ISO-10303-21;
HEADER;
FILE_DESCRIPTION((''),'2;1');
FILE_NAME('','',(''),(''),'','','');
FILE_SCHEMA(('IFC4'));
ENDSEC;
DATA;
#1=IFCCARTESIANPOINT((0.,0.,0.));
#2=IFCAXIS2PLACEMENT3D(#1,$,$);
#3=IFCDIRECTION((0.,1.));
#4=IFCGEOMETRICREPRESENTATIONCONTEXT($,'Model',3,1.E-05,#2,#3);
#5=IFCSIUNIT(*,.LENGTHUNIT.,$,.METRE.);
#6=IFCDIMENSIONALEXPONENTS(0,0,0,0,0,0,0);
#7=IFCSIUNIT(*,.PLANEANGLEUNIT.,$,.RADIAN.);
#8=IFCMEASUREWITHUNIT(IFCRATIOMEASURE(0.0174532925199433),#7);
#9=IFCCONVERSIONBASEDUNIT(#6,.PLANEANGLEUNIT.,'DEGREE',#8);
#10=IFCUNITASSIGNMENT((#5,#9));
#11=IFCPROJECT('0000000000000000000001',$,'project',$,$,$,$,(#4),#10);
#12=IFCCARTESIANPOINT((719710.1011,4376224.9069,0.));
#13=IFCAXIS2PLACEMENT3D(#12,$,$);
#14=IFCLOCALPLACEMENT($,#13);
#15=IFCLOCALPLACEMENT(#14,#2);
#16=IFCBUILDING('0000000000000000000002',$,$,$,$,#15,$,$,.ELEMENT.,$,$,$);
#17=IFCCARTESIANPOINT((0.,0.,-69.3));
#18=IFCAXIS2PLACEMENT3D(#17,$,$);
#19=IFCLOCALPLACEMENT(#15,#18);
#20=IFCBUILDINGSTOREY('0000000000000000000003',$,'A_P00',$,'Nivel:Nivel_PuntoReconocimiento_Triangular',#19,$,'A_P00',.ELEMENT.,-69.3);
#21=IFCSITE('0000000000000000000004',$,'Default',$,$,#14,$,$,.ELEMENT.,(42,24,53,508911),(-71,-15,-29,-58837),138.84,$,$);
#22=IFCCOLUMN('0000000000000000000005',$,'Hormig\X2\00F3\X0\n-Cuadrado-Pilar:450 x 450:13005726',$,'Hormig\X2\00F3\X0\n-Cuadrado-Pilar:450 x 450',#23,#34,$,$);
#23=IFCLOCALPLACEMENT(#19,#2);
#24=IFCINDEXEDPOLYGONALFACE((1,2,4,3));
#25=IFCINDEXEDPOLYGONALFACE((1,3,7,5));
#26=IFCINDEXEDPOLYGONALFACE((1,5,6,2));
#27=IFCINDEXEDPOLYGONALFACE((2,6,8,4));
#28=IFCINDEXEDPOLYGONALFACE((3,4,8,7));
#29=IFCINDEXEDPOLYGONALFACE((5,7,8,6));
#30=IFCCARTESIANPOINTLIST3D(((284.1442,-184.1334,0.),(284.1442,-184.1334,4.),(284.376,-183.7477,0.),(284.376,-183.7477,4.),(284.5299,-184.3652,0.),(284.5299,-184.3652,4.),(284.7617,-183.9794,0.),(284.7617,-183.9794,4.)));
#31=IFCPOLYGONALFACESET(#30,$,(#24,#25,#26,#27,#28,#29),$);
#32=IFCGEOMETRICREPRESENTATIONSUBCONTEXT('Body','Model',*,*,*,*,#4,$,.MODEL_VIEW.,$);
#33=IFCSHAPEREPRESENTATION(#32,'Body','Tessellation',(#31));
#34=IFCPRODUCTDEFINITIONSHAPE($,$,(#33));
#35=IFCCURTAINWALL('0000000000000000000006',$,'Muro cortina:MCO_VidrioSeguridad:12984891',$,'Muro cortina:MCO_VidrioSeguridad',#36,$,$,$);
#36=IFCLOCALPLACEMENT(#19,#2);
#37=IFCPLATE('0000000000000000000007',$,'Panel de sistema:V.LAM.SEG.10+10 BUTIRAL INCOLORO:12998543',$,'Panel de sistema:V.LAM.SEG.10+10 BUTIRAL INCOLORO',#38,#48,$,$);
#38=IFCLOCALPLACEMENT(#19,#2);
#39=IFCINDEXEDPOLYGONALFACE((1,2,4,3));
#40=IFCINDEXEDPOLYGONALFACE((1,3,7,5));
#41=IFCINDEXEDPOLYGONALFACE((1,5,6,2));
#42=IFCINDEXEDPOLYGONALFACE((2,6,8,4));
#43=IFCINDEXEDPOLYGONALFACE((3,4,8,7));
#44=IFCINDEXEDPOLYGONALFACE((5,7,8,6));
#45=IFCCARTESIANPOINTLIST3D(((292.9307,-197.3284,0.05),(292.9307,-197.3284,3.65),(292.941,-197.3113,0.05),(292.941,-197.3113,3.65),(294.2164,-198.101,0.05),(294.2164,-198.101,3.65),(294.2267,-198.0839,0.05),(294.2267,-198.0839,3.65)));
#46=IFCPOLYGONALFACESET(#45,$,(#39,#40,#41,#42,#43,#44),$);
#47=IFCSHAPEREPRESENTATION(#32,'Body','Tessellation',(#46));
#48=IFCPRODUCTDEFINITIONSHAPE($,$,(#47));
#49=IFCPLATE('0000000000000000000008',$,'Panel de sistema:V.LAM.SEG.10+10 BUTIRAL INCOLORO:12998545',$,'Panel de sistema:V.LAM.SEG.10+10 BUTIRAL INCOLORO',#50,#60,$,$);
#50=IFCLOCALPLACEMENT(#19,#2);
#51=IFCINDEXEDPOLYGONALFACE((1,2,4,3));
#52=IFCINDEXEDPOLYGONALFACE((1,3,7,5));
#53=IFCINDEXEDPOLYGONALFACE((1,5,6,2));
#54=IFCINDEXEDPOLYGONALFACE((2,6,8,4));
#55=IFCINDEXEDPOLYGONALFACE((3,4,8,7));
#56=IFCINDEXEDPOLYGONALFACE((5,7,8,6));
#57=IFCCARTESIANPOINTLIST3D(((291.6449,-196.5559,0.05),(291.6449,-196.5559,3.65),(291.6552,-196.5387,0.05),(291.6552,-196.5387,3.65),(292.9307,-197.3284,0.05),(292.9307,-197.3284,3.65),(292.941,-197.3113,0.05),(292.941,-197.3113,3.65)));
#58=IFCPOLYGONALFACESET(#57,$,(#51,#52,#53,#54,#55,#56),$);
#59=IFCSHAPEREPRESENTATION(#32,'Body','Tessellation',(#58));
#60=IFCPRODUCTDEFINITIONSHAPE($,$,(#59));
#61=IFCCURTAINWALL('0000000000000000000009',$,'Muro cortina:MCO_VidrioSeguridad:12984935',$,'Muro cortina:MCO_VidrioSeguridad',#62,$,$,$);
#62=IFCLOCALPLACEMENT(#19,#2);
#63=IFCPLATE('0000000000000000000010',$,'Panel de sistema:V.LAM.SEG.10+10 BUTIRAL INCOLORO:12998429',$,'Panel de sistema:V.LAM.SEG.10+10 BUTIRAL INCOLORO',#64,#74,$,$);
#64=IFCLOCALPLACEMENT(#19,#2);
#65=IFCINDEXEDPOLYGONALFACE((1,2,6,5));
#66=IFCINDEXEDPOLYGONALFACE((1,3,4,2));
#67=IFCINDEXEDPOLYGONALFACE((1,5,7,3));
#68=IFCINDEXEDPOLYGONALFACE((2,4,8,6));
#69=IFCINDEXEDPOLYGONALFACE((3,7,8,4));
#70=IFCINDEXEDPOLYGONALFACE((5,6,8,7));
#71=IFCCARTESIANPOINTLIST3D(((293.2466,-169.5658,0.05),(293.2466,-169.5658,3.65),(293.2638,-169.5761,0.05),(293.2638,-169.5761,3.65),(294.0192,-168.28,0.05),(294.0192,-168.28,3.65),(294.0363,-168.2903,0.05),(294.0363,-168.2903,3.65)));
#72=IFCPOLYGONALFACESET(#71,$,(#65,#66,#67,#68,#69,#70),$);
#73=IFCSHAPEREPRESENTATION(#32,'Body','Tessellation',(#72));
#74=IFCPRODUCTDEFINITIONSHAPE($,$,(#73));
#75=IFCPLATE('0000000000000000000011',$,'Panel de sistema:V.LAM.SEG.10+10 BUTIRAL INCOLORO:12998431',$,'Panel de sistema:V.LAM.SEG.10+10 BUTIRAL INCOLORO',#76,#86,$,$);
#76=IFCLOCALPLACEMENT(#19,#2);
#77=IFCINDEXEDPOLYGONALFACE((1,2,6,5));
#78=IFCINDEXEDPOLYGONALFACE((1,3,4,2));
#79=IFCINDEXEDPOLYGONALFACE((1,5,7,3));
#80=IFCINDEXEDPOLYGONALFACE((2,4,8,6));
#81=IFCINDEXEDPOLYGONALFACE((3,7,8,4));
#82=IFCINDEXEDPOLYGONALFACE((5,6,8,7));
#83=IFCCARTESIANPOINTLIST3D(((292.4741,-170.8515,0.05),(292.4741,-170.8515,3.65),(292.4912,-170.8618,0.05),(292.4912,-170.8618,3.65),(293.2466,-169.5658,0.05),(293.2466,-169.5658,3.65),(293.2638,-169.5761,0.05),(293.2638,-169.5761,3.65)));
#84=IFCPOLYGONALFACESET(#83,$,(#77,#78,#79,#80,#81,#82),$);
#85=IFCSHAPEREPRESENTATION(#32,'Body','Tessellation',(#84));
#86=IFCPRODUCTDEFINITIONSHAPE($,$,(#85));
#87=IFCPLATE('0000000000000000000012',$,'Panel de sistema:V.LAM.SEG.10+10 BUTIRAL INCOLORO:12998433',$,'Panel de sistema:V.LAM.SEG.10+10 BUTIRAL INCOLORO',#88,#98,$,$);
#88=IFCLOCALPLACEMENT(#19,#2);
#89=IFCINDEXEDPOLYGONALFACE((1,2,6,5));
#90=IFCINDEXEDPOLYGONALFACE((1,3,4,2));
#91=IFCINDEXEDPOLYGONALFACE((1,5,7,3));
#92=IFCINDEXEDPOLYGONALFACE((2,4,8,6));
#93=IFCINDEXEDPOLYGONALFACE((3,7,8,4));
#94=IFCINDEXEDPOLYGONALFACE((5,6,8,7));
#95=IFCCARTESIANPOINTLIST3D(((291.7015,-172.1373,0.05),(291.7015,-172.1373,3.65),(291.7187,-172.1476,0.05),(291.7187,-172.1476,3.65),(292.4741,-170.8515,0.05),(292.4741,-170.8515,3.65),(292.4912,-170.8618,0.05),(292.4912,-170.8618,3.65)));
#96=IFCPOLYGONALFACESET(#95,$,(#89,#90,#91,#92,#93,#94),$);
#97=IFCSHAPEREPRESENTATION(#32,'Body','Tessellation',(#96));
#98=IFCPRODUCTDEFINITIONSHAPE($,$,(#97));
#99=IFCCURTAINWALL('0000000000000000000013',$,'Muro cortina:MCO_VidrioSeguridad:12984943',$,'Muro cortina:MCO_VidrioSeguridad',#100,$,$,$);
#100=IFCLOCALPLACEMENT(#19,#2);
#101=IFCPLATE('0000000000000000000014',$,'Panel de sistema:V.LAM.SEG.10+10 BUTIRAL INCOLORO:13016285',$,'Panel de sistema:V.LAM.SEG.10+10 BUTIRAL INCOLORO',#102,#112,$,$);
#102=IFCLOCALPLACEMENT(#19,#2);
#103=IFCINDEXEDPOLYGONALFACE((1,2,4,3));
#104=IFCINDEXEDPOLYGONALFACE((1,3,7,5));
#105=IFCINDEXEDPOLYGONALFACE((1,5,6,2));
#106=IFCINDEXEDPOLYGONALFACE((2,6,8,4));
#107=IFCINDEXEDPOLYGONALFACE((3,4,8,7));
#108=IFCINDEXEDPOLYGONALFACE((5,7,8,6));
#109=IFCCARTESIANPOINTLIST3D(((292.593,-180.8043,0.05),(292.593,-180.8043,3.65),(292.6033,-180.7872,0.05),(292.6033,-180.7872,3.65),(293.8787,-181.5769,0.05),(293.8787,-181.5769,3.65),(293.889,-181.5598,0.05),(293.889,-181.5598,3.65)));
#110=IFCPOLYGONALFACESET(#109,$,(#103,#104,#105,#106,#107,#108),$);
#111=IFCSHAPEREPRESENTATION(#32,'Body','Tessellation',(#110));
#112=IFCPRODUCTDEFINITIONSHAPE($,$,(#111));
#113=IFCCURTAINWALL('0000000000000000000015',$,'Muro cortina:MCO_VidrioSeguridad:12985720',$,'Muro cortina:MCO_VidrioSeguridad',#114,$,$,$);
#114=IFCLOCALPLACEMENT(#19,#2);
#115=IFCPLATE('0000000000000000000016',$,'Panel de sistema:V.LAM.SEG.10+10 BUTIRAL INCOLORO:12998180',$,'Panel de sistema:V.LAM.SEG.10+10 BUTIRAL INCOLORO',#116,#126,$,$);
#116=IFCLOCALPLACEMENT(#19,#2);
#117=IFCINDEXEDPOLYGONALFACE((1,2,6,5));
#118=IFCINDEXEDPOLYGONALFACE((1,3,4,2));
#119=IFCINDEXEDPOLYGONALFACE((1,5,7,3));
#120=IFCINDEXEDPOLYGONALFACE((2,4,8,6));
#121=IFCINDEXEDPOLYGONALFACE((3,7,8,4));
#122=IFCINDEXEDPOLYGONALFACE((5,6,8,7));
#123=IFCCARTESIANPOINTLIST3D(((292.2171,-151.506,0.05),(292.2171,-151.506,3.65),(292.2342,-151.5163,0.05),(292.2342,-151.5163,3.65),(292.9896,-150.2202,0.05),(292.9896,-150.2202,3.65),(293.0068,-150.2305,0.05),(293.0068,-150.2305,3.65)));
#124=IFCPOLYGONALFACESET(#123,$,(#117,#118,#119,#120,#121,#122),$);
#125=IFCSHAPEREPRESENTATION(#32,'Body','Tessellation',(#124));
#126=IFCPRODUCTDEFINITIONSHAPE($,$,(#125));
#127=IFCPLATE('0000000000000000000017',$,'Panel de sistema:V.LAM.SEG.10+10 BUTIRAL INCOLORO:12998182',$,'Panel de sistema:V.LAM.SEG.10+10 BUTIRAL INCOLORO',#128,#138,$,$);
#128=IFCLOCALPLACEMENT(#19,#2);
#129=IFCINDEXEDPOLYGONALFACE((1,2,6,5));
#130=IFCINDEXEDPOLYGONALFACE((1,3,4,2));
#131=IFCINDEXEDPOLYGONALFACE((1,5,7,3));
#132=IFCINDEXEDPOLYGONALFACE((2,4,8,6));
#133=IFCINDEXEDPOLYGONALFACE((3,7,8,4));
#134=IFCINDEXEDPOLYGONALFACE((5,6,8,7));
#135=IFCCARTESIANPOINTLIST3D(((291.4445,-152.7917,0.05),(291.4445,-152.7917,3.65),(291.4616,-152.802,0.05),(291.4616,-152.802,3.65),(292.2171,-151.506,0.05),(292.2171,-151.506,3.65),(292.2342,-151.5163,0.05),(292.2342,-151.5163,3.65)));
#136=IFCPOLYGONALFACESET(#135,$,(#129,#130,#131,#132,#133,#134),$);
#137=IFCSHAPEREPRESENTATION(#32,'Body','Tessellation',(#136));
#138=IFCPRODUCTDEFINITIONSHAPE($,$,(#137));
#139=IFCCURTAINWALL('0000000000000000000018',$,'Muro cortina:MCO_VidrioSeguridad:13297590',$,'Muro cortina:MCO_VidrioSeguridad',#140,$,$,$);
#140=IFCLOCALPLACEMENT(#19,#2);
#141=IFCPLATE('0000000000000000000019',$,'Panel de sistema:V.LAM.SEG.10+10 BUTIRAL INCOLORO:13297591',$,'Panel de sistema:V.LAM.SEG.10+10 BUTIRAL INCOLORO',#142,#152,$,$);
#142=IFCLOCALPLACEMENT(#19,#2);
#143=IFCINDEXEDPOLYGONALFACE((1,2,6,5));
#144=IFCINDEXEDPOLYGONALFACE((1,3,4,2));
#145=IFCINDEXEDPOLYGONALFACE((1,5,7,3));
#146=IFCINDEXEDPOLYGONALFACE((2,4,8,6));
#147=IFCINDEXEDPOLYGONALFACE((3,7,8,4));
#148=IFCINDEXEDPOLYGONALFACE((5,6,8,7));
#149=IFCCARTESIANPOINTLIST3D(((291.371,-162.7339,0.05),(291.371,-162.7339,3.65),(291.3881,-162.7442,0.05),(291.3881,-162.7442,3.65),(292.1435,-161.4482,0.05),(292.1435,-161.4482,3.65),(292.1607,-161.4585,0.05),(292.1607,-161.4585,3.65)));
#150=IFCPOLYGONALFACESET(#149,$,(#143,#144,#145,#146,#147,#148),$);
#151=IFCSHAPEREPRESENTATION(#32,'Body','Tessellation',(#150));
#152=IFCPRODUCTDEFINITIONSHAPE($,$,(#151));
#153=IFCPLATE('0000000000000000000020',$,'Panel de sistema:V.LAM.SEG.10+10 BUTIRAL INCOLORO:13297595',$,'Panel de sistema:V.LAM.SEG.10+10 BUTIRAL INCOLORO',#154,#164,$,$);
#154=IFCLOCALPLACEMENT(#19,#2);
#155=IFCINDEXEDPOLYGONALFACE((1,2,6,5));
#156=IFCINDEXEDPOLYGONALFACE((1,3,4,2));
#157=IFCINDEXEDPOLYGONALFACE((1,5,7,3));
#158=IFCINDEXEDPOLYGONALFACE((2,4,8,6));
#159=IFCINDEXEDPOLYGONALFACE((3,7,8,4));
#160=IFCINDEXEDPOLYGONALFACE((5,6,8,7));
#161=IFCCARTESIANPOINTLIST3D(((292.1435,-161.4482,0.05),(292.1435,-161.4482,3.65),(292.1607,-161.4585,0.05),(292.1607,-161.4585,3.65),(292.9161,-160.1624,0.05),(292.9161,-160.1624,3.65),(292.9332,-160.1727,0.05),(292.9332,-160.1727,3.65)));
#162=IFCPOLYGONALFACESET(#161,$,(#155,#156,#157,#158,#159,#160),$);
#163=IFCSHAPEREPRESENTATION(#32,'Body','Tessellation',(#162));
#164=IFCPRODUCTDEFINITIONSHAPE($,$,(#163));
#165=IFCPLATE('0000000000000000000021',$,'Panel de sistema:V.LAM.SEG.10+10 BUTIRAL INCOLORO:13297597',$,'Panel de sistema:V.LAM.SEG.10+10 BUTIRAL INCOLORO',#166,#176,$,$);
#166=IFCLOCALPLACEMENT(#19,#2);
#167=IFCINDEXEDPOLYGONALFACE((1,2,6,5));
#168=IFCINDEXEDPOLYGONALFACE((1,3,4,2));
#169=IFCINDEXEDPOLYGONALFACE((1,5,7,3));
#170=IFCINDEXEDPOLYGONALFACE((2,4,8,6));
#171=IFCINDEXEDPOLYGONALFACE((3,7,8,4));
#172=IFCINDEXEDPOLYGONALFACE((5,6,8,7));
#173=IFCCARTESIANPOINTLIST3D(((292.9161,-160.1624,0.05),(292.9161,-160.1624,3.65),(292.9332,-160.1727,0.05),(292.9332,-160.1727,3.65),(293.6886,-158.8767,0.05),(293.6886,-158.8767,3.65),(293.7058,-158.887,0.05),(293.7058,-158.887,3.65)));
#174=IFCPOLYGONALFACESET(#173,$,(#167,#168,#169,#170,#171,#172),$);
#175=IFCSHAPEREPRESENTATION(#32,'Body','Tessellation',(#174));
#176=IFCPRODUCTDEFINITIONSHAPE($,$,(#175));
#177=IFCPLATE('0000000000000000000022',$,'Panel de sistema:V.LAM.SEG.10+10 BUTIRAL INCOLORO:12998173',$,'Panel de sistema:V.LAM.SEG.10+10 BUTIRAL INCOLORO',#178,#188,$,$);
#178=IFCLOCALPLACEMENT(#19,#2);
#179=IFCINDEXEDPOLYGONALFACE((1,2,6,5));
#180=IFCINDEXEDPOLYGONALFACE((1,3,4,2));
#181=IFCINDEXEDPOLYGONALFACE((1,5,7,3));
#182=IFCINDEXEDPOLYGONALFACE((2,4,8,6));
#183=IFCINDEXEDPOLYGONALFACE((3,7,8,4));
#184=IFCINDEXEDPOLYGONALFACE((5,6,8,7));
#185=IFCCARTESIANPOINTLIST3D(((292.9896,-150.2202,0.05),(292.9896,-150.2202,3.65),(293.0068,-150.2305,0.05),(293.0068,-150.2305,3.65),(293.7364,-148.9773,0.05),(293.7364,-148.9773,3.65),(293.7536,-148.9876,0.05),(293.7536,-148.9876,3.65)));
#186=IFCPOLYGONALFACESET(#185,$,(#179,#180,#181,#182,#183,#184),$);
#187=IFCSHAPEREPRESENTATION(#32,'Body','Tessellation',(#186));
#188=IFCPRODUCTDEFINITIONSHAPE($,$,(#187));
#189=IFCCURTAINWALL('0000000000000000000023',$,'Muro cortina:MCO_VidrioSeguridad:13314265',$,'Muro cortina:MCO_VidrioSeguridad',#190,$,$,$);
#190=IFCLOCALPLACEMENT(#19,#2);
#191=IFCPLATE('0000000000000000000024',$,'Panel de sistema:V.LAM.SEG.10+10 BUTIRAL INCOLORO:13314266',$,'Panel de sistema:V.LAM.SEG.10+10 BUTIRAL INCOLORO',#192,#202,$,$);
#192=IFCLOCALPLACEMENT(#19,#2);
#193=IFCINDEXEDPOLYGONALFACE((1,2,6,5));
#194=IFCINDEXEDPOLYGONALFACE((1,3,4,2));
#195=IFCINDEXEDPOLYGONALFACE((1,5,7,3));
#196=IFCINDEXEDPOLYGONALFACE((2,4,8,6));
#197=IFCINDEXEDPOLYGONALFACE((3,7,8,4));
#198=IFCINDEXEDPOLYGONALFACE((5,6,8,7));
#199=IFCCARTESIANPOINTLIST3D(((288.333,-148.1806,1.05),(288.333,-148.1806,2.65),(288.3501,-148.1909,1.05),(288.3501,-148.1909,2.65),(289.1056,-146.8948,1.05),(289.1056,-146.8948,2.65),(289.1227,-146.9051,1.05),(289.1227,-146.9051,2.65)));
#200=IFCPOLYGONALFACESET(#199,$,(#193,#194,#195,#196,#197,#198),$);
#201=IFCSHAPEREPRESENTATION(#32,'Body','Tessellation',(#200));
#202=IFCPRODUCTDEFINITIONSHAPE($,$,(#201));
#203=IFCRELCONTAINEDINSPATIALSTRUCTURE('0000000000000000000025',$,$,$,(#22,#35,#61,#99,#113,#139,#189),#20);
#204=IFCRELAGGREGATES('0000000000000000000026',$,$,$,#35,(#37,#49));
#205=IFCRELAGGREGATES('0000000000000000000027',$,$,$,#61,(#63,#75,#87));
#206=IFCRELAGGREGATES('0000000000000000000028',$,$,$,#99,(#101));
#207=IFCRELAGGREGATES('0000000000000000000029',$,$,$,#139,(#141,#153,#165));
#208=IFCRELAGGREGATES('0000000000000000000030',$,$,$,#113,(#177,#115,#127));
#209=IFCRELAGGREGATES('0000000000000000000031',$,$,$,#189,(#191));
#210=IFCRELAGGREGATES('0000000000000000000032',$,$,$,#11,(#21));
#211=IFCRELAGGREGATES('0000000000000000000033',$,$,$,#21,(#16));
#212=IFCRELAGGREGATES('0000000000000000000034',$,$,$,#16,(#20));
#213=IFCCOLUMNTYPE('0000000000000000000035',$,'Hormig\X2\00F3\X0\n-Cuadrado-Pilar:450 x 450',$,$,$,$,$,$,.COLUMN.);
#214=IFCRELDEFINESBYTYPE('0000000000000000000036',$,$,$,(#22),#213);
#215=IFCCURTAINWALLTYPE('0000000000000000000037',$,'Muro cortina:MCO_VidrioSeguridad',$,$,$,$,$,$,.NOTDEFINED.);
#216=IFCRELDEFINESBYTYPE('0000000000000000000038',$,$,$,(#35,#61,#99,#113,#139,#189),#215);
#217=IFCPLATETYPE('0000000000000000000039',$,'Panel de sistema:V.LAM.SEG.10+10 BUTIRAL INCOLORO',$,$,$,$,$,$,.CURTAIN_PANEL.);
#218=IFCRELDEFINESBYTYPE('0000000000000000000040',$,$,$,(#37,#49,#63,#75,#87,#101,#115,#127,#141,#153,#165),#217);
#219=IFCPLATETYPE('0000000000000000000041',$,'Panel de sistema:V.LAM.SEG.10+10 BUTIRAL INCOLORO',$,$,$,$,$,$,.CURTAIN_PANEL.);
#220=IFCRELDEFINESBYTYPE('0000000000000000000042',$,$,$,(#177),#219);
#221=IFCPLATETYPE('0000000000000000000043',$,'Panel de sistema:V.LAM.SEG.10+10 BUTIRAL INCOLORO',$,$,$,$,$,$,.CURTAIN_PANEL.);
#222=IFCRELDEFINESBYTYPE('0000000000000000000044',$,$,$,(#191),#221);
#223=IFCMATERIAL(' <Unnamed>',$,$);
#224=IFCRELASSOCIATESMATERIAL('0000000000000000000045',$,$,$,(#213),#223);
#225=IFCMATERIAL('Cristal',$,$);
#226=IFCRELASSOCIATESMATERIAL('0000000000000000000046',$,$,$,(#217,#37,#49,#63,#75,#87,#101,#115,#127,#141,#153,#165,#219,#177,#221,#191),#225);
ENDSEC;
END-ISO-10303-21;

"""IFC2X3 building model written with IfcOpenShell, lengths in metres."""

from ifc_helpers import new_model, entity, si_unit, converted_unit, direction, frame, frame_2d, origin, origin_2d_with_axis, place, context, subcontext, project, spatial, rectangle, extrude, source, transform, mapped, material, type_object, type_shapes, element, aggregate, save


model = new_model("IFC2X3")

# Units and contexts
model_context = context("Model", 3, precision=1e-05, world=origin(), true_north=direction((0.0, 1.0)))
body_context = subcontext(model_context, "Body", "Model", "MODEL_VIEW")
ifc_project = project(units=[si_unit("LENGTHUNIT", "METRE"), converted_unit("PLANEANGLEUNIT", "DEGREE", entity("IfcRatioMeasure", 0.0174532925199433), si_unit("PLANEANGLEUNIT", "RADIAN"), dimensions=[0, 0, 0, 0, 0, 0, 0])], contexts=[model_context])

# Site, building, storey
site_placement = place(None, frame((719710.1011, 4376224.9069, 0.0)))
site = spatial("IfcSite", under=ifc_project, at=site_placement, Name="Default", CompositionType="ELEMENT", RefLatitude=(42, 24, 53, 508911), RefLongitude=(-71, -15, -29, -58837), RefElevation=138.84)
building_placement = place(site_placement, origin())
building = spatial("IfcBuilding", under=site, at=building_placement, CompositionType="ELEMENT")
storey_placement = place(building_placement, frame((0.0, 0.0, -69.3)))
storey = spatial("IfcBuildingStorey", under=building, at=storey_placement, Name="A_P00", ObjectType="Nivel:Nivel_PuntoReconocimiento_Triangular", LongName="A_P00", CompositionType="ELEMENT", Elevation=-69.3)

# Column
ifc_material_1 = material(Name=" <Unnamed>")
column_type = type_object("IfcColumnType", Name="Hormigón-Cuadrado-Pilar:450 x 450", PredefinedType="COLUMN", material=ifc_material_1)
shared_shape_1 = source(origin(), body_context, "Body", "SweptSolid", [
    extrude(rectangle(XDim=0.45, YDim=0.45, at=origin_2d_with_axis()), frame((0.0, 0.0, -69.3), z_axis=(0.0, 0.0, 1.0), x_axis=(0.0, -1.0, 0.0)), (0.0, 0.0, 1.0), 4.0),
])
type_shapes(column_type, [shared_shape_1])
column_placement = place(storey_placement, frame((284.4529, -184.0564, 69.3), z_axis=(0.0, 0.0, 1.0), x_axis=(0.857167, -0.515038, 0.0)))
element("IfcColumn", 1, at=column_placement, inside=storey, type_object=column_type, Name="Hormigón-Cuadrado-Pilar:450 x 450:13005726", ObjectType="Hormigón-Cuadrado-Pilar:450 x 450", context=body_context, shape_type="MappedRepresentation", body=[
    mapped(shared_shape_1, transform((0.0, 0.0, 0.0), scale=1.0)),
])

# Curtain walls, plates
curtain_wall_type = type_object("IfcCurtainWallType", Name="Muro cortina:MCO_VidrioSeguridad", PredefinedType="NOTDEFINED")
curtain_wall_1_placement = place(storey_placement, frame((0.0, 0.0, 69.3)))
curtain_wall_1 = element("IfcCurtainWall", 2, at=curtain_wall_1_placement, inside=storey, type_object=curtain_wall_type, Name="Muro cortina:MCO_VidrioSeguridad:12984891", ObjectType="Muro cortina:MCO_VidrioSeguridad")
ifc_material_2 = material(Name="Cristal")
plate_type_1 = type_object("IfcPlateType", Name="Panel de sistema:V.LAM.SEG.10+10 BUTIRAL INCOLORO", PredefinedType="CURTAIN_PANEL", material=ifc_material_2)
shared_shape_2 = source(origin(), body_context, "Body", "SweptSolid", [
    extrude(rectangle(XDim=0.02, YDim=1.5, at=origin_2d_with_axis()), frame((0.0, 0.0, 0.0), z_axis=(0.0, 0.0, 1.0), x_axis=(0.0, 1.0, 0.0)), (0.0, 0.0, 1.0), 3.6),
])
type_shapes(plate_type_1, [shared_shape_2])
plate_1_placement = place(curtain_wall_1_placement, frame((293.5787, -197.7062, -69.25), z_axis=(0.0, 0.0, 1.0), x_axis=(-0.857167, 0.515038, 0.0)))
plate_1 = element("IfcPlate", 3, at=plate_1_placement, type_object=plate_type_1, material=ifc_material_2, Name="Panel de sistema:V.LAM.SEG.10+10 BUTIRAL INCOLORO:12998543", ObjectType="Panel de sistema:V.LAM.SEG.10+10 BUTIRAL INCOLORO", context=body_context, shape_type="MappedRepresentation", body=[
    mapped(shared_shape_2, transform((0.0, 0.0, 0.0), scale=1.0)),
])
plate_2_placement = place(curtain_wall_1_placement, frame((292.2929, -196.9336, -69.25), z_axis=(0.0, 0.0, 1.0), x_axis=(-0.857167, 0.515038, 0.0)))
plate_2 = element("IfcPlate", 4, at=plate_2_placement, type_object=plate_type_1, material=ifc_material_2, Name="Panel de sistema:V.LAM.SEG.10+10 BUTIRAL INCOLORO:12998545", ObjectType="Panel de sistema:V.LAM.SEG.10+10 BUTIRAL INCOLORO", context=body_context, shape_type="MappedRepresentation", body=[
    mapped(shared_shape_2, transform((0.0, 0.0, 0.0), scale=1.0)),
])
aggregate(curtain_wall_1, [plate_1, plate_2])
curtain_wall_2_placement = place(storey_placement, frame((0.0, 0.0, 69.3)))
curtain_wall_2 = element("IfcCurtainWall", 5, at=curtain_wall_2_placement, inside=storey, type_object=curtain_wall_type, Name="Muro cortina:MCO_VidrioSeguridad:12984935", ObjectType="Muro cortina:MCO_VidrioSeguridad")
plate_3_placement = place(curtain_wall_2_placement, frame((293.6415, -168.928, -69.25), z_axis=(0.0, 0.0, 1.0), x_axis=(-0.515038, -0.857167, 0.0)))
plate_3 = element("IfcPlate", 6, at=plate_3_placement, type_object=plate_type_1, material=ifc_material_2, Name="Panel de sistema:V.LAM.SEG.10+10 BUTIRAL INCOLORO:12998429", ObjectType="Panel de sistema:V.LAM.SEG.10+10 BUTIRAL INCOLORO", context=body_context, shape_type="MappedRepresentation", body=[
    mapped(shared_shape_2, transform((0.0, 0.0, 0.0), scale=1.0)),
])
plate_4_placement = place(curtain_wall_2_placement, frame((292.8689, -170.2138, -69.25), z_axis=(0.0, 0.0, 1.0), x_axis=(-0.515038, -0.857167, 0.0)))
plate_4 = element("IfcPlate", 7, at=plate_4_placement, type_object=plate_type_1, material=ifc_material_2, Name="Panel de sistema:V.LAM.SEG.10+10 BUTIRAL INCOLORO:12998431", ObjectType="Panel de sistema:V.LAM.SEG.10+10 BUTIRAL INCOLORO", context=body_context, shape_type="MappedRepresentation", body=[
    mapped(shared_shape_2, transform((0.0, 0.0, 0.0), scale=1.0)),
])
plate_5_placement = place(curtain_wall_2_placement, frame((292.0964, -171.4995, -69.25), z_axis=(0.0, 0.0, 1.0), x_axis=(-0.515038, -0.857167, 0.0)))
plate_5 = element("IfcPlate", 8, at=plate_5_placement, type_object=plate_type_1, material=ifc_material_2, Name="Panel de sistema:V.LAM.SEG.10+10 BUTIRAL INCOLORO:12998433", ObjectType="Panel de sistema:V.LAM.SEG.10+10 BUTIRAL INCOLORO", context=body_context, shape_type="MappedRepresentation", body=[
    mapped(shared_shape_2, transform((0.0, 0.0, 0.0), scale=1.0)),
])
aggregate(curtain_wall_2, [plate_3, plate_4, plate_5])

# Curtain wall, plate
curtain_wall_3_placement = place(storey_placement, frame((0.0, 0.0, 69.3)))
curtain_wall_3 = element("IfcCurtainWall", 9, at=curtain_wall_3_placement, inside=storey, type_object=curtain_wall_type, Name="Muro cortina:MCO_VidrioSeguridad:12984943", ObjectType="Muro cortina:MCO_VidrioSeguridad")
plate_6_placement = place(curtain_wall_3_placement, frame((293.241, -181.1821, -69.25), z_axis=(0.0, 0.0, 1.0), x_axis=(0.857167, -0.515038, 0.0)))
plate_6 = element("IfcPlate", 10, at=plate_6_placement, type_object=plate_type_1, material=ifc_material_2, Name="Panel de sistema:V.LAM.SEG.10+10 BUTIRAL INCOLORO:13016285", ObjectType="Panel de sistema:V.LAM.SEG.10+10 BUTIRAL INCOLORO", context=body_context, shape_type="MappedRepresentation", body=[
    mapped(shared_shape_2, transform((0.0, 0.0, 0.0), scale=1.0)),
])
aggregate(curtain_wall_3, [plate_6])

# Curtain walls, plates
curtain_wall_4_placement = place(storey_placement, frame((0.0, 0.0, 69.3)))
curtain_wall_4 = element("IfcCurtainWall", 11, at=curtain_wall_4_placement, inside=storey, type_object=curtain_wall_type, Name="Muro cortina:MCO_VidrioSeguridad:12985720", ObjectType="Muro cortina:MCO_VidrioSeguridad")
plate_7_placement = place(curtain_wall_4_placement, frame((292.6119, -150.8682, -69.25), z_axis=(0.0, 0.0, 1.0), x_axis=(-0.515038, -0.857167, 0.0)))
plate_7 = element("IfcPlate", 12, at=plate_7_placement, type_object=plate_type_1, material=ifc_material_2, Name="Panel de sistema:V.LAM.SEG.10+10 BUTIRAL INCOLORO:12998180", ObjectType="Panel de sistema:V.LAM.SEG.10+10 BUTIRAL INCOLORO", context=body_context, shape_type="MappedRepresentation", body=[
    mapped(shared_shape_2, transform((0.0, 0.0, 0.0), scale=1.0)),
])
plate_8_placement = place(curtain_wall_4_placement, frame((291.8394, -152.154, -69.25), z_axis=(0.0, 0.0, 1.0), x_axis=(-0.515038, -0.857167, 0.0)))
plate_8 = element("IfcPlate", 13, at=plate_8_placement, type_object=plate_type_1, material=ifc_material_2, Name="Panel de sistema:V.LAM.SEG.10+10 BUTIRAL INCOLORO:12998182", ObjectType="Panel de sistema:V.LAM.SEG.10+10 BUTIRAL INCOLORO", context=body_context, shape_type="MappedRepresentation", body=[
    mapped(shared_shape_2, transform((0.0, 0.0, 0.0), scale=1.0)),
])
curtain_wall_5_placement = place(storey_placement, frame((0.0, 0.0, 69.3)))
curtain_wall_5 = element("IfcCurtainWall", 14, at=curtain_wall_5_placement, inside=storey, type_object=curtain_wall_type, Name="Muro cortina:MCO_VidrioSeguridad:13297590", ObjectType="Muro cortina:MCO_VidrioSeguridad")
plate_9_placement = place(curtain_wall_5_placement, frame((291.7658, -162.0962, -69.25), z_axis=(0.0, 0.0, 1.0), x_axis=(0.515038, 0.857167, 0.0)))
plate_9 = element("IfcPlate", 15, at=plate_9_placement, type_object=plate_type_1, material=ifc_material_2, Name="Panel de sistema:V.LAM.SEG.10+10 BUTIRAL INCOLORO:13297591", ObjectType="Panel de sistema:V.LAM.SEG.10+10 BUTIRAL INCOLORO", context=body_context, shape_type="MappedRepresentation", body=[
    mapped(shared_shape_2, transform((0.0, 0.0, 0.0), scale=1.0)),
])
plate_10_placement = place(curtain_wall_5_placement, frame((292.5384, -160.8104, -69.25), z_axis=(0.0, 0.0, 1.0), x_axis=(0.515038, 0.857167, 0.0)))
plate_10 = element("IfcPlate", 16, at=plate_10_placement, type_object=plate_type_1, material=ifc_material_2, Name="Panel de sistema:V.LAM.SEG.10+10 BUTIRAL INCOLORO:13297595", ObjectType="Panel de sistema:V.LAM.SEG.10+10 BUTIRAL INCOLORO", context=body_context, shape_type="MappedRepresentation", body=[
    mapped(shared_shape_2, transform((0.0, 0.0, 0.0), scale=1.0)),
])
plate_11_placement = place(curtain_wall_5_placement, frame((293.3109, -159.5247, -69.25), z_axis=(0.0, 0.0, 1.0), x_axis=(0.515038, 0.857167, 0.0)))
plate_11 = element("IfcPlate", 17, at=plate_11_placement, type_object=plate_type_1, material=ifc_material_2, Name="Panel de sistema:V.LAM.SEG.10+10 BUTIRAL INCOLORO:13297597", ObjectType="Panel de sistema:V.LAM.SEG.10+10 BUTIRAL INCOLORO", context=body_context, shape_type="MappedRepresentation", body=[
    mapped(shared_shape_2, transform((0.0, 0.0, 0.0), scale=1.0)),
])
aggregate(curtain_wall_5, [plate_9, plate_10, plate_11])

# Plate
plate_type_2 = type_object("IfcPlateType", Name="Panel de sistema:V.LAM.SEG.10+10 BUTIRAL INCOLORO", PredefinedType="CURTAIN_PANEL", material=ifc_material_2)
shared_shape_3 = source(origin(), body_context, "Body", "SweptSolid", [
    extrude(rectangle(XDim=0.02, YDim=1.45, at=origin_2d_with_axis()), frame((0.0, 0.0, 0.0), z_axis=(0.0, 0.0, 1.0), x_axis=(0.0, 1.0, 0.0)), (0.0, 0.0, 1.0), 3.6),
])
type_shapes(plate_type_2, [shared_shape_3])
plate_12_placement = place(curtain_wall_4_placement, frame((293.3716, -149.6039, -69.25), z_axis=(0.0, 0.0, 1.0), x_axis=(-0.515038, -0.857167, 0.0)))
plate_12 = element("IfcPlate", 18, at=plate_12_placement, type_object=plate_type_2, material=ifc_material_2, Name="Panel de sistema:V.LAM.SEG.10+10 BUTIRAL INCOLORO:12998173", ObjectType="Panel de sistema:V.LAM.SEG.10+10 BUTIRAL INCOLORO", context=body_context, shape_type="MappedRepresentation", body=[
    mapped(shared_shape_3, transform((0.0, 0.0, 0.0), scale=1.0)),
])
aggregate(curtain_wall_4, [plate_12, plate_7, plate_8])

# Curtain wall, plate
curtain_wall_6_placement = place(storey_placement, frame((0.0, 0.0, 69.3)))
curtain_wall_6 = element("IfcCurtainWall", 19, at=curtain_wall_6_placement, inside=storey, type_object=curtain_wall_type, Name="Muro cortina:MCO_VidrioSeguridad:13314265", ObjectType="Muro cortina:MCO_VidrioSeguridad")
plate_type_3 = type_object("IfcPlateType", Name="Panel de sistema:V.LAM.SEG.10+10 BUTIRAL INCOLORO", PredefinedType="CURTAIN_PANEL", material=ifc_material_2)
shared_shape_4 = source(origin(), body_context, "Body", "SweptSolid", [
    extrude(rectangle(XDim=0.02, YDim=1.5, at=frame_2d((0.0, 0.0), x_axis=(1.0, 0.0))), frame((0.0, 0.0, 0.0), z_axis=(0.0, 0.0, 1.0), x_axis=(0.0, 1.0, 0.0)), (0.0, 0.0, 1.0), 1.6),
])
type_shapes(plate_type_3, [shared_shape_4])
plate_13_placement = place(curtain_wall_6_placement, frame((288.7279, -147.5428, -68.25), z_axis=(0.0, 0.0, 1.0), x_axis=(-0.515038, -0.857167, 0.0)))
plate_13 = element("IfcPlate", 20, at=plate_13_placement, type_object=plate_type_3, material=ifc_material_2, Name="Panel de sistema:V.LAM.SEG.10+10 BUTIRAL INCOLORO:13314266", ObjectType="Panel de sistema:V.LAM.SEG.10+10 BUTIRAL INCOLORO", context=body_context, shape_type="MappedRepresentation", body=[
    mapped(shared_shape_4, transform((0.0, 0.0, 0.0), scale=1.0)),
])
aggregate(curtain_wall_6, [plate_13])

save(model, "model.ifc")
